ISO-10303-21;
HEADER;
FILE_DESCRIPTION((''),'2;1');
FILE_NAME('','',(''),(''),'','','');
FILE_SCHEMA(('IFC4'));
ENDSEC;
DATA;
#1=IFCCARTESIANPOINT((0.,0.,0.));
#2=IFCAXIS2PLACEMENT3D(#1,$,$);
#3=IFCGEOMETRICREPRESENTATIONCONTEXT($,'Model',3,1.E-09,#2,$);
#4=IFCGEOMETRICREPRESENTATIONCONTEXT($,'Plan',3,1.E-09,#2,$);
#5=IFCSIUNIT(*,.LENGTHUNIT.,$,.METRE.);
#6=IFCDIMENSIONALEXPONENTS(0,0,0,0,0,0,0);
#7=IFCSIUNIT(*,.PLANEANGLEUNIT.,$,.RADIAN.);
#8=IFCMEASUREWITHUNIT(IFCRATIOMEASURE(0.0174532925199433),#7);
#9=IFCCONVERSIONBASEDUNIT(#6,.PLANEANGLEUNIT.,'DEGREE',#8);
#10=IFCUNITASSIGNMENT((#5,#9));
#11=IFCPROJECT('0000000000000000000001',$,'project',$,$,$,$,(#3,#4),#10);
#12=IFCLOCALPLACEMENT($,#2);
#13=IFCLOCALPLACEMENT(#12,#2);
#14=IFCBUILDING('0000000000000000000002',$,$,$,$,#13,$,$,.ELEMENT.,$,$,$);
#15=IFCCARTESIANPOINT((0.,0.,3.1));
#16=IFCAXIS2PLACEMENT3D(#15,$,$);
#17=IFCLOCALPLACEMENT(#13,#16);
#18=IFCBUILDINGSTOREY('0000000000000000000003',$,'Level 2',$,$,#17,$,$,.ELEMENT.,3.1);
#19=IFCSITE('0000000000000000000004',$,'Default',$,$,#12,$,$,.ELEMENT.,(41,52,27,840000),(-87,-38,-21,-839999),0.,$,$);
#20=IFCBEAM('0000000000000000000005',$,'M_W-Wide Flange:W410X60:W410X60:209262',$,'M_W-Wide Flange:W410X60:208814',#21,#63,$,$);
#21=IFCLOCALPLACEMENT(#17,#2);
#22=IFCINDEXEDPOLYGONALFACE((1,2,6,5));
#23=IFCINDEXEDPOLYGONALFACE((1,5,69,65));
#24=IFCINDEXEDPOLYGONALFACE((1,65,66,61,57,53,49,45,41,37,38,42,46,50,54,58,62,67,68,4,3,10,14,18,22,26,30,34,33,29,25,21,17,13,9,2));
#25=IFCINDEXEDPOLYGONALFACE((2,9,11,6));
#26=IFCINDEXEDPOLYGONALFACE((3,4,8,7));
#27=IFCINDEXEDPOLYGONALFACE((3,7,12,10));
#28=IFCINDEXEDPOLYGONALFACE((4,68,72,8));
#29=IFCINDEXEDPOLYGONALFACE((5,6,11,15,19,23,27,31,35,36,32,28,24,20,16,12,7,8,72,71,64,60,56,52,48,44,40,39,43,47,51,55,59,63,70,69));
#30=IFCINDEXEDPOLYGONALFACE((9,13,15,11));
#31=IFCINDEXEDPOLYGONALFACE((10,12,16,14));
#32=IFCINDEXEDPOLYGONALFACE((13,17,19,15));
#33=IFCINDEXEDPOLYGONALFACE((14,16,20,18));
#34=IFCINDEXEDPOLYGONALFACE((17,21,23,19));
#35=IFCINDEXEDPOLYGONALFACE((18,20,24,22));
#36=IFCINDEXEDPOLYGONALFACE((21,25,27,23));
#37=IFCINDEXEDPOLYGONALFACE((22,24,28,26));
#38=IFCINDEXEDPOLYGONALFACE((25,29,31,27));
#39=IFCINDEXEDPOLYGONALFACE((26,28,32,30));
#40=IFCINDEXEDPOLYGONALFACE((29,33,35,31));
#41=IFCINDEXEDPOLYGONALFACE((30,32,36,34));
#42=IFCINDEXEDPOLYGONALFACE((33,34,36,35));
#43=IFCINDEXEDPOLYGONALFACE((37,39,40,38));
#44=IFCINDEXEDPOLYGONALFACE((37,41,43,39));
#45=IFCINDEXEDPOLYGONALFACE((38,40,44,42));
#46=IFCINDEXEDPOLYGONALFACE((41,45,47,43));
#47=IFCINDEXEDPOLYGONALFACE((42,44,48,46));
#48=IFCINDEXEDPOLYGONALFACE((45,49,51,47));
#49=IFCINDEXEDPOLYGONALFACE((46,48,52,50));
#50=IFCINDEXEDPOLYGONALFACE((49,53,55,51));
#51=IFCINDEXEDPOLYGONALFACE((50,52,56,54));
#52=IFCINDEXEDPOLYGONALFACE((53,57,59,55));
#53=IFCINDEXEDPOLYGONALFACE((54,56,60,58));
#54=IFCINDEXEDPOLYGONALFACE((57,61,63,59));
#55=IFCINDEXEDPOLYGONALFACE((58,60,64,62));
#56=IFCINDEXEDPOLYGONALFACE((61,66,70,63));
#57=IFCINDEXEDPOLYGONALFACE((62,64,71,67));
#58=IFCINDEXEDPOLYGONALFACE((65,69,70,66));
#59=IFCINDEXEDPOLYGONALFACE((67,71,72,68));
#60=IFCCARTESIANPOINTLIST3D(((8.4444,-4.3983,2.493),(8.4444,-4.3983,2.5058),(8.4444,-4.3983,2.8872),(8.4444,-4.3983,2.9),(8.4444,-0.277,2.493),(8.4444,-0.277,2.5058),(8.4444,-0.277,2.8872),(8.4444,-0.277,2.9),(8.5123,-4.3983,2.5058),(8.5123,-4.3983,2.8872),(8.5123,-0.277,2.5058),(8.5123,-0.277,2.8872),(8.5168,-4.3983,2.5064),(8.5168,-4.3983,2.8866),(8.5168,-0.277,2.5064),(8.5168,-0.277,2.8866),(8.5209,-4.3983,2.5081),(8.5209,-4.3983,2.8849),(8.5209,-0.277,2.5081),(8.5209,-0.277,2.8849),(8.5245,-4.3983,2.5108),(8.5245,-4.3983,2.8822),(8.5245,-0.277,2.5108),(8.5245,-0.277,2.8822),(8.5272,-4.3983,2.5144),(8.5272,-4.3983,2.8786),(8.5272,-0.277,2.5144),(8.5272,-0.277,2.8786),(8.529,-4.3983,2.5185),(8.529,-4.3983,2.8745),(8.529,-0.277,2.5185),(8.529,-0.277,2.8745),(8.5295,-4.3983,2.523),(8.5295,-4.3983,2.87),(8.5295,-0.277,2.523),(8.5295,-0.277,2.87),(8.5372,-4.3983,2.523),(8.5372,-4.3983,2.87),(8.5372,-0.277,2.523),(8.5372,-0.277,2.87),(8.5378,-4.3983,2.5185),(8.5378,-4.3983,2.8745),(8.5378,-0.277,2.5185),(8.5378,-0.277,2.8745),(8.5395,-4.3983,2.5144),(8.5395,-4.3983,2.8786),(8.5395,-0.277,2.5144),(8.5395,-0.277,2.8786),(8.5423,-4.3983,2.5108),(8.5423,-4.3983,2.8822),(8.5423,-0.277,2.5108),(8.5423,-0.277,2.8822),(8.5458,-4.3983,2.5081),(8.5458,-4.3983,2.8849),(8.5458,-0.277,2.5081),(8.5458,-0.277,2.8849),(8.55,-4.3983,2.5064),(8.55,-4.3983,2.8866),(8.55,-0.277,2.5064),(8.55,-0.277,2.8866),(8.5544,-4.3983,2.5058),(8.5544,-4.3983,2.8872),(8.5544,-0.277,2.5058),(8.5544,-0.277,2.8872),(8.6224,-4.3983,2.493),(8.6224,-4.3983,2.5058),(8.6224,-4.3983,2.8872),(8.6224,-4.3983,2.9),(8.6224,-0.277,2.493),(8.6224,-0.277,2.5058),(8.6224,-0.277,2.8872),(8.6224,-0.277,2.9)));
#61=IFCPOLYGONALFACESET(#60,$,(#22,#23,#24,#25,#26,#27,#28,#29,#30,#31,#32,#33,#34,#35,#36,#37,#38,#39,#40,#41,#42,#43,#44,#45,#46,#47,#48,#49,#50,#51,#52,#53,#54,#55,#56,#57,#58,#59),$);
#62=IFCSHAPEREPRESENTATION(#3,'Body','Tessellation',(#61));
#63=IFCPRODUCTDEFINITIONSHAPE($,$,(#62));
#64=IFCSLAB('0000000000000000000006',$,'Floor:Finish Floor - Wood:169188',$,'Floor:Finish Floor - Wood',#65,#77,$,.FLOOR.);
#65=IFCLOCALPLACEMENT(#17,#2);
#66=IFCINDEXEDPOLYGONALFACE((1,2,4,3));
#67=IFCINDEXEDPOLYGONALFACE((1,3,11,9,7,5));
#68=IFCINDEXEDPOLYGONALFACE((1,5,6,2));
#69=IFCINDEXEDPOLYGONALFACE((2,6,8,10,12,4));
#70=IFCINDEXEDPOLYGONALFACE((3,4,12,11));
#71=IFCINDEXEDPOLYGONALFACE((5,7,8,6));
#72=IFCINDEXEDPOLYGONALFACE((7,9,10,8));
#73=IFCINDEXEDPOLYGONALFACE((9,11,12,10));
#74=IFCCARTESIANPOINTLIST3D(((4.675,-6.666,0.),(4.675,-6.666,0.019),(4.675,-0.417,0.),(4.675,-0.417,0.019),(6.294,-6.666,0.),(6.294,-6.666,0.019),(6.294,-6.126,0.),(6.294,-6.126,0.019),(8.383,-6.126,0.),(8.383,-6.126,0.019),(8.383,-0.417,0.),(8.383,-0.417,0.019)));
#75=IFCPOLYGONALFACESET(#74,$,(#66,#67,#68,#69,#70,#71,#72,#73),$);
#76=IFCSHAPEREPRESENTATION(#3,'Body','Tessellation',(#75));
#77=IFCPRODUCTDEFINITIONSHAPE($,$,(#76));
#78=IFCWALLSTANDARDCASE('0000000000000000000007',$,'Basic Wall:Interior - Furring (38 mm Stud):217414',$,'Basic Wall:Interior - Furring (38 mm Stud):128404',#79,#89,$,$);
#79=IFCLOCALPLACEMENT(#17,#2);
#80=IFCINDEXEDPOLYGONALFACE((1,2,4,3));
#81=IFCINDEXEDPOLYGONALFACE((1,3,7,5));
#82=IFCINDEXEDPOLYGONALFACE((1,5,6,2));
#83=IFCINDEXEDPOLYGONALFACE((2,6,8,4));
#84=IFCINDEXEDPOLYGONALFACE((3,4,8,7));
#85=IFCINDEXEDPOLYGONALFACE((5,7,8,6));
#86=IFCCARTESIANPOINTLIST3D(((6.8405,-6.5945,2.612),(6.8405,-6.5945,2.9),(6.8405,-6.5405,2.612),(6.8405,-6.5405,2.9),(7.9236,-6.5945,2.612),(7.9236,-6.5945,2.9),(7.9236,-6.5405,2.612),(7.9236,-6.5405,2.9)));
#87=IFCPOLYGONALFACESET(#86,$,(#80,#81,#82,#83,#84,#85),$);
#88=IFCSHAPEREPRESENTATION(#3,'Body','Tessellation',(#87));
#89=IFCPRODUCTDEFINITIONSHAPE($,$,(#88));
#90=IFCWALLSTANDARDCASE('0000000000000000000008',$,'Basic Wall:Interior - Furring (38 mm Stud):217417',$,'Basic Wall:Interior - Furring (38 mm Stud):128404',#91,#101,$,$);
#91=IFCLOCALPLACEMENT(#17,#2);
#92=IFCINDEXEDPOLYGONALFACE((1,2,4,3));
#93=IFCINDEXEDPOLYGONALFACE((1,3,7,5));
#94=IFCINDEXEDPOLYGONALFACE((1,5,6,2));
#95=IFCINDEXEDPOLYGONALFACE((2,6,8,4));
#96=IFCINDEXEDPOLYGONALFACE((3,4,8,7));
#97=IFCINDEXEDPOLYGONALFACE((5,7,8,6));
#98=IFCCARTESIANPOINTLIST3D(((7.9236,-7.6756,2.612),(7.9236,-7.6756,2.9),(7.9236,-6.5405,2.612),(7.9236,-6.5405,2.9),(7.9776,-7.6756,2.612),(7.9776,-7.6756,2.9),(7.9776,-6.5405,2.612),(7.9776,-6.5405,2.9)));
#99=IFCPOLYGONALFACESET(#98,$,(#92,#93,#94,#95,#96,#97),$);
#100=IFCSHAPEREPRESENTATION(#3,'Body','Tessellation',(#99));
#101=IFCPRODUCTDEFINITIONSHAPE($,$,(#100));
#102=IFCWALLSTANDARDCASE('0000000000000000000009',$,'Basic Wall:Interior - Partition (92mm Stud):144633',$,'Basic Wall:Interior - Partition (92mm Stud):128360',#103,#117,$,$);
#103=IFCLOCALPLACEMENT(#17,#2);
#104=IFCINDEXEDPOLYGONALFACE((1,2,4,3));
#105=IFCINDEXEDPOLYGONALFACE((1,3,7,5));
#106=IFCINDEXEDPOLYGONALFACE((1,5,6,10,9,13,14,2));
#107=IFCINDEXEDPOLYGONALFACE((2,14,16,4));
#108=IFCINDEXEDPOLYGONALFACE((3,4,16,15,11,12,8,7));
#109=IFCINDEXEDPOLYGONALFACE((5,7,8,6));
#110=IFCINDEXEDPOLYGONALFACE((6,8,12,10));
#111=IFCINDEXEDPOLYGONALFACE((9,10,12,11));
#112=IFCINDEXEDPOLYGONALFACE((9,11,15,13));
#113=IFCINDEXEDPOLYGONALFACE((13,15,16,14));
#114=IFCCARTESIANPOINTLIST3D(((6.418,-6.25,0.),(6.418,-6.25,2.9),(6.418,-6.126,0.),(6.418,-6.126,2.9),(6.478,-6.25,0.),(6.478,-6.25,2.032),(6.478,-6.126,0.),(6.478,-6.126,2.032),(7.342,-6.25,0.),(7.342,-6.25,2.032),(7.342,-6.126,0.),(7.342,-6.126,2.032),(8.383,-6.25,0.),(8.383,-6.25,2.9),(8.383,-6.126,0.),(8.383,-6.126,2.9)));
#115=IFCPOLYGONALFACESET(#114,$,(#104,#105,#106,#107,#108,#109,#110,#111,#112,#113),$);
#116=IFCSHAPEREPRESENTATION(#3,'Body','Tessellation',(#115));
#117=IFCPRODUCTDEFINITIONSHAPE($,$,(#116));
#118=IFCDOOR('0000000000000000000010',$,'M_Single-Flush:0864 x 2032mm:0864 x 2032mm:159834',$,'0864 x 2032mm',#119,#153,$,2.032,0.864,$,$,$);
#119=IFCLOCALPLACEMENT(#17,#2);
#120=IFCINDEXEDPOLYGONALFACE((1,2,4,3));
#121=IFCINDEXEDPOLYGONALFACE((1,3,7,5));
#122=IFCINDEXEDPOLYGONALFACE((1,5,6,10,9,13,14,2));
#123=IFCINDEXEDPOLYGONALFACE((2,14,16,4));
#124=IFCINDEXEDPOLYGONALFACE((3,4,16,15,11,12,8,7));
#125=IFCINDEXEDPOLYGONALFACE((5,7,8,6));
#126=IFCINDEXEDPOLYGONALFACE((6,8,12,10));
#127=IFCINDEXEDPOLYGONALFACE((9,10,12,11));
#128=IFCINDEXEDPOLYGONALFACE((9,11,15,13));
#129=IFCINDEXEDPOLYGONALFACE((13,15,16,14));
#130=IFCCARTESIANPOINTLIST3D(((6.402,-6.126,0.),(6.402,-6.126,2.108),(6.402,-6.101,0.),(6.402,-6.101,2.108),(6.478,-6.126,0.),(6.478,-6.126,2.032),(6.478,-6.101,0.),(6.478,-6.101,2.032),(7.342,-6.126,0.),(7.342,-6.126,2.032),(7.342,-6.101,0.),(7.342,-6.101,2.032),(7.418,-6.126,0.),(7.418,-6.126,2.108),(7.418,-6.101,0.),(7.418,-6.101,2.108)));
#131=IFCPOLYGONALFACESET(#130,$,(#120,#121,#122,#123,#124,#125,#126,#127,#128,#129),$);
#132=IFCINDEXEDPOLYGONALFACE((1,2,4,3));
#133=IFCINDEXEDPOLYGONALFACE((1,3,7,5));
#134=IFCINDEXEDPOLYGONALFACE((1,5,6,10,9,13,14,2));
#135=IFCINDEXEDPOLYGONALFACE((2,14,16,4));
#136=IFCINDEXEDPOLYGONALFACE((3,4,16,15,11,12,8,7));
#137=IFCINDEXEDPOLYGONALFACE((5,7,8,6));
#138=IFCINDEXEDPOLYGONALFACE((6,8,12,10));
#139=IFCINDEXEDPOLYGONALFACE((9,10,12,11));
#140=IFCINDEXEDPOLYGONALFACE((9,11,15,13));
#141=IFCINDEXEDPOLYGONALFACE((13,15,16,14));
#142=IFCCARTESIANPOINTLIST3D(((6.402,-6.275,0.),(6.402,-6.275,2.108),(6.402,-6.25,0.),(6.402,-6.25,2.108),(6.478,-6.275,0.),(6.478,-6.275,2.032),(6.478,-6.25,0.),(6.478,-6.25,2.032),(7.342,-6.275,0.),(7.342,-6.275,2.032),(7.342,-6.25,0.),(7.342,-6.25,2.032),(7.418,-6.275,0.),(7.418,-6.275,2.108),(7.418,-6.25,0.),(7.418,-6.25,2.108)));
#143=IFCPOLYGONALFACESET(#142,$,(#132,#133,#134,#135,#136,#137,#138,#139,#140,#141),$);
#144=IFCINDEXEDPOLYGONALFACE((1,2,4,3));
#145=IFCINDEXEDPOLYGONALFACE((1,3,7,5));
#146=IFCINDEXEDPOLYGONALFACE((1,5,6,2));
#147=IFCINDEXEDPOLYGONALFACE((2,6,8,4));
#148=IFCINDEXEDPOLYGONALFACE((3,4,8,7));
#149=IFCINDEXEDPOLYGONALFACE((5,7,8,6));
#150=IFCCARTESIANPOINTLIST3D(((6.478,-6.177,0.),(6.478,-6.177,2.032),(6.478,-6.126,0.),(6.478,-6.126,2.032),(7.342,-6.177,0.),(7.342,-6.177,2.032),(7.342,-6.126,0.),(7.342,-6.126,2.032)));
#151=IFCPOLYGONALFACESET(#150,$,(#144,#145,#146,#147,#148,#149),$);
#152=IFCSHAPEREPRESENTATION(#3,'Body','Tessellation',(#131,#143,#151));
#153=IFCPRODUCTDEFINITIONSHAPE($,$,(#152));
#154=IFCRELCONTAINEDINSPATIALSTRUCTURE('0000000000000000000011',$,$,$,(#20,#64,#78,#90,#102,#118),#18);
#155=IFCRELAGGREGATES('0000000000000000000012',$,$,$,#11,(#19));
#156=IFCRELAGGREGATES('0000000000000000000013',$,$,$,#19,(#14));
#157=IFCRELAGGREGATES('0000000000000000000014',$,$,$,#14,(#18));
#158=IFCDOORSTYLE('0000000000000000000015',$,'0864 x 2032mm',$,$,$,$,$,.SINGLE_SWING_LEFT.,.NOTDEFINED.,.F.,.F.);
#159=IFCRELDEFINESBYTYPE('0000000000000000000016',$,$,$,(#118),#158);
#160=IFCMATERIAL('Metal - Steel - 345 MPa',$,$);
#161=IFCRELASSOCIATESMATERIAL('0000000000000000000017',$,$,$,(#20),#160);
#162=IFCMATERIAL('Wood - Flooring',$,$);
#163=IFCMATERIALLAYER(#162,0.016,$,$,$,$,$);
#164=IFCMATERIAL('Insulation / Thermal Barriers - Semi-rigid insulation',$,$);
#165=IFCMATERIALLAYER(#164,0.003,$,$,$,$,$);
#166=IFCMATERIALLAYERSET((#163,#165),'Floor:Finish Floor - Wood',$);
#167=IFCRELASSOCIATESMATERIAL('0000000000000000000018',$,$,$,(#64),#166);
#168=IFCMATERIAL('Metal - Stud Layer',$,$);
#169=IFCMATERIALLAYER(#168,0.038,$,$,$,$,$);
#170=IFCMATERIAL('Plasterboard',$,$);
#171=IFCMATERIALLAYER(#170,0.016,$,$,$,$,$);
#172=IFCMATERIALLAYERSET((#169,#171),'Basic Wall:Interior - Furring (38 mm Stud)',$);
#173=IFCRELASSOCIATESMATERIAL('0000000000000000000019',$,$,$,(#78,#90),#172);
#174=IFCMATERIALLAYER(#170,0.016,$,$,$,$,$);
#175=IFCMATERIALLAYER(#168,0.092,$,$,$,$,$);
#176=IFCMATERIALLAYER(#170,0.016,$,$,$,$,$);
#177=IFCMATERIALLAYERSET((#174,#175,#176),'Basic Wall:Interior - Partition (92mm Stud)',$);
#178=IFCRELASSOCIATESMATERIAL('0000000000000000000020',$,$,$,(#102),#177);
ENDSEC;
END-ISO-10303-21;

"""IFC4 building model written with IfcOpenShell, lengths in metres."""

from ifc_helpers import new_model, entity, si_unit, converted_unit, frame, frame_2d, origin, origin_2d_with_axis, place, context, project, spatial, polyline, circle_curve, parameter, trimmed, segment, composite_curve, rectangle, outline, extrude, source, transform, mapped, material, layer, layer_set, layer_usage, type_object, type_shapes, element, fill, save


model = new_model("IFC4")

# Units and contexts
model_context = context("Model", 3, precision=1e-09, world=origin())
plan_context = context("Plan", 3, precision=1e-09, world=origin())
ifc_project = project(units=[si_unit("LENGTHUNIT", "METRE"), converted_unit("PLANEANGLEUNIT", "DEGREE", entity("IfcRatioMeasure", 0.0174532925199433), si_unit("PLANEANGLEUNIT", "RADIAN"), dimensions=[0, 0, 0, 0, 0, 0, 0])], contexts=[model_context, plan_context])

# Site, building, storey
site_placement = place(None, origin())
site = spatial("IfcSite", under=ifc_project, at=site_placement, Name="Default", CompositionType="ELEMENT", RefLatitude=(41, 52, 27, 840000), RefLongitude=(-87, -38, -21, -839999), RefElevation=0.0)
building_placement = place(site_placement, origin())
building = spatial("IfcBuilding", under=site, at=building_placement, CompositionType="ELEMENT")
storey_placement = place(building_placement, frame((0.0, 0.0, 3.1)))
storey = spatial("IfcBuildingStorey", under=building, at=storey_placement, Name="Level 2", CompositionType="ELEMENT", Elevation=3.1)

# Beam
ifc_material_1 = material(Name="Metal - Steel - 345 MPa")
beam_1_placement = place(storey_placement, frame((8.5334, -4.3983, 2.9)))
element("IfcBeam", 1, at=beam_1_placement, inside=storey, material=ifc_material_1, Name="M_W-Wide Flange:W410X60:W410X60:209262", ObjectType="M_W-Wide Flange:W410X60:208814", context=model_context, shape_type="SweptSolid", body=[
    extrude(outline(composite_curve([segment(polyline([(-0.089, -0.1907), (-0.089, -0.2035)]), True, "CONTINUOUS"), segment(polyline([(-0.089, -0.2035), (0.089, -0.2035)]), True, "CONTINUOUS"), segment(polyline([(0.089, -0.2035), (0.089, -0.1907)]), True, "CONTINUOUS"), segment(polyline([(0.089, -0.1907), (0.021, -0.1907)]), True, "CONTINUOUS"), segment(trimmed(circle_curve(frame_2d((0.021, -0.1735), x_axis=(0.0, -1.0)), 0.0172), [parameter(270.0)], [parameter(360.0)], True, "PARAMETER"), False, "CONTINUOUS"), segment(polyline([(0.0038, -0.1735), (0.0038, 0.1735)]), True, "CONTINUOUS"), segment(trimmed(circle_curve(frame_2d((0.021, 0.1735), x_axis=(-1.0, 0.0)), 0.0172), [parameter(270.0)], [parameter(360.0)], True, "PARAMETER"), False, "CONTINUOUS"), segment(polyline([(0.021, 0.1907), (0.089, 0.1907)]), True, "CONTINUOUS"), segment(polyline([(0.089, 0.1907), (0.089, 0.2035)]), True, "CONTINUOUS"), segment(polyline([(0.089, 0.2035), (-0.089, 0.2035)]), True, "CONTINUOUS"), segment(polyline([(-0.089, 0.2035), (-0.089, 0.1907)]), True, "CONTINUOUS"), segment(polyline([(-0.089, 0.1907), (-0.0211, 0.1907)]), True, "CONTINUOUS"), segment(trimmed(circle_curve(frame_2d((-0.0211, 0.1735), x_axis=(0.0, 1.0)), 0.0172), [parameter(270.0)], [parameter(0.0)], True, "PARAMETER"), False, "CONTINUOUS"), segment(polyline([(-0.0039, 0.1735), (-0.0039, -0.1735)]), True, "CONTINUOUS"), segment(trimmed(circle_curve(frame_2d((-0.0211, -0.1735), x_axis=(1.0, 0.0)), 0.0172), [parameter(270.0)], [parameter(0.0)], True, "PARAMETER"), False, "CONTINUOUS"), segment(polyline([(-0.0211, -0.1907), (-0.089, -0.1907)]), True, "CONTINUOUS")], self_intersect=False)), frame((0.0, 0.0, -0.2035), z_axis=(0.0, -1.0, 0.0), x_axis=(1.0, 0.0, 0.0)), (0.0, 0.0, -1.0), 4.1213),
])

# Slab
ifc_material_2 = material(Name="Wood - Flooring")
ifc_layer_1 = layer(ifc_material_2, 0.016)
ifc_material_3 = material(Name="Insulation / Thermal Barriers - Semi-rigid insulation")
ifc_layer_2 = layer(ifc_material_3, 0.003)
ifc_layer_set_1 = layer_set([ifc_layer_1, ifc_layer_2], Name="Floor:Finish Floor - Wood")
ifc_layer_usage_1 = layer_usage(ifc_layer_set_1, "AXIS3", "POSITIVE", 0.0)
slab_placement = place(storey_placement, frame((4.675, -6.666, 0.0)))
element("IfcSlab", 2, at=slab_placement, inside=storey, material=ifc_layer_usage_1, Name="Floor:Finish Floor - Wood:169188", ObjectType="Floor:Finish Floor - Wood", PredefinedType="FLOOR", context=model_context, shape_type="SweptSolid", body=[
    extrude(outline(polyline([(-1.854, 3.1245), (-1.854, -2.5845), (0.235, -2.5845), (0.235, -3.1245), (1.854, -3.1245), (1.854, 3.1245), (-1.854, 3.1245)])), frame((1.854, 3.1245, 0.019), z_axis=(0.0, 0.0, -1.0), x_axis=(-1.0, 0.0, 0.0)), (0.0, 0.0, 1.0), 0.019),
])

# Shared definitions
ifc_material_4 = material(Name="Metal - Stud Layer")
ifc_material_5 = material(Name="Plasterboard")

# Walls
ifc_layer_3 = layer(ifc_material_4, 0.038)
ifc_layer_4 = layer(ifc_material_5, 0.016)
ifc_layer_set_2 = layer_set([ifc_layer_3, ifc_layer_4], Name="Basic Wall:Interior - Furring (38 mm Stud)")
ifc_layer_usage_2 = layer_usage(ifc_layer_set_2, "AXIS2", "NEGATIVE", 0.027)
wall_1_placement = place(storey_placement, frame((6.8405, -6.5675, 2.612)))
element("IfcWallStandardCase", 3, at=wall_1_placement, inside=storey, material=ifc_layer_usage_2, Name="Basic Wall:Interior - Furring (38 mm Stud):217414", ObjectType="Basic Wall:Interior - Furring (38 mm Stud):128404", context=model_context, shape_type="SweptSolid", body=[
    extrude(rectangle(XDim=1.0831, YDim=0.054, at=frame_2d((0.5415, 0.0), x_axis=(-1.0, 0.0))), origin(), (0.0, 0.0, 1.0), 0.288),
])
ifc_layer_usage_3 = layer_usage(ifc_layer_set_2, "AXIS2", "NEGATIVE", 0.027)
wall_2_placement = place(storey_placement, frame((7.9506, -6.5405, 2.612), z_axis=(0.0, 0.0, 1.0), x_axis=(0.0, -1.0, 0.0)))
element("IfcWallStandardCase", 4, at=wall_2_placement, inside=storey, material=ifc_layer_usage_3, Name="Basic Wall:Interior - Furring (38 mm Stud):217417", ObjectType="Basic Wall:Interior - Furring (38 mm Stud):128404", context=model_context, shape_type="SweptSolid", body=[
    extrude(rectangle(XDim=1.1351, YDim=0.054, at=frame_2d((0.5675, 0.0), x_axis=(-1.0, 0.0))), origin(), (0.0, 0.0, 1.0), 0.288),
])

# Wall, opening, door
ifc_layer_5 = layer(ifc_material_5, 0.016)
ifc_layer_6 = layer(ifc_material_4, 0.092)
ifc_layer_7 = layer(ifc_material_5, 0.016)
ifc_layer_set_3 = layer_set([ifc_layer_5, ifc_layer_6, ifc_layer_7], Name="Basic Wall:Interior - Partition (92mm Stud)")
ifc_layer_usage_4 = layer_usage(ifc_layer_set_3, "AXIS2", "NEGATIVE", 0.062)
wall_3_placement = place(storey_placement, frame((6.418, -6.188, 0.0)))
wall_3 = element("IfcWallStandardCase", 5, at=wall_3_placement, inside=storey, material=ifc_layer_usage_4, Name="Basic Wall:Interior - Partition (92mm Stud):144633", ObjectType="Basic Wall:Interior - Partition (92mm Stud):128360", context=model_context, shape_type="SweptSolid", body=[
    extrude(rectangle(XDim=1.965, YDim=0.124, at=frame_2d((0.9825, 0.0), x_axis=(-1.0, 0.0))), origin(), (0.0, 0.0, 1.0), 2.9),
])
opening_1_placement = place(wall_3_placement, frame((0.06, -0.062, 0.0)))
opening_1 = element("IfcOpeningElement", 6, at=opening_1_placement, cuts=wall_3, ObjectType="Opening", context=model_context, shape_type="SweptSolid", body=[
    extrude(rectangle(XDim=0.864, YDim=2.032, at=frame_2d((1.016, 0.432), x_axis=(0.0, -1.0))), frame((0.0, 0.0, 0.0), z_axis=(0.0, 1.0, 0.0), x_axis=(0.0, 0.0, 1.0)), (0.0, 0.0, 1.0), 0.124),
])
door_style_1 = type_object("IfcDoorStyle", Name="0864 x 2032mm", ConstructionType="NOTDEFINED", OperationType="SINGLE_SWING_LEFT", ParameterTakesPrecedence=False, Sizeable=False)
shared_shape_1 = source(origin(), model_context, "Body", "SweptSolid", [
    extrude(outline(polyline([(-0.508, -1.073), (0.508, -1.073), (0.508, 1.035), (0.432, 1.035), (0.432, -0.997), (-0.432, -0.997), (-0.432, 1.035), (-0.508, 1.035), (-0.508, -1.073)])), frame((0.432, 0.149, 1.035), z_axis=(0.0, -1.0, 0.0), x_axis=(-1.0, 0.0, 0.0)), (0.0, 0.0, 1.0), 0.025),
    extrude(outline(polyline([(-1.073, -0.508), (1.035, -0.508), (1.035, -0.432), (-0.997, -0.432), (-0.997, 0.432), (1.035, 0.432), (1.035, 0.508), (-1.073, 0.508), (-1.073, -0.508)])), frame((0.432, 0.0, 1.035), z_axis=(0.0, -1.0, 0.0), x_axis=(0.0, 0.0, -1.0)), (0.0, 0.0, 1.0), 0.025),
    extrude(rectangle(XDim=0.864, YDim=0.051, at=origin_2d_with_axis()), frame((0.432, 0.0985, 0.0)), (0.0, 0.0, 1.0), 2.032),
])
type_shapes(door_style_1, [shared_shape_1])
door_1_placement = place(opening_1_placement, origin())
door_1 = element("IfcDoor", 7, at=door_1_placement, inside=storey, type_object=door_style_1, Name="M_Single-Flush:0864 x 2032mm:0864 x 2032mm:159834", ObjectType="0864 x 2032mm", OverallHeight=2.032, OverallWidth=0.864, context=model_context, shape_type="MappedRepresentation", body=[
    mapped(shared_shape_1, transform((0.0, 0.0, 0.0), scale=1.0)),
])
fill(opening_1, door_1)

save(model, "model.ifc")
